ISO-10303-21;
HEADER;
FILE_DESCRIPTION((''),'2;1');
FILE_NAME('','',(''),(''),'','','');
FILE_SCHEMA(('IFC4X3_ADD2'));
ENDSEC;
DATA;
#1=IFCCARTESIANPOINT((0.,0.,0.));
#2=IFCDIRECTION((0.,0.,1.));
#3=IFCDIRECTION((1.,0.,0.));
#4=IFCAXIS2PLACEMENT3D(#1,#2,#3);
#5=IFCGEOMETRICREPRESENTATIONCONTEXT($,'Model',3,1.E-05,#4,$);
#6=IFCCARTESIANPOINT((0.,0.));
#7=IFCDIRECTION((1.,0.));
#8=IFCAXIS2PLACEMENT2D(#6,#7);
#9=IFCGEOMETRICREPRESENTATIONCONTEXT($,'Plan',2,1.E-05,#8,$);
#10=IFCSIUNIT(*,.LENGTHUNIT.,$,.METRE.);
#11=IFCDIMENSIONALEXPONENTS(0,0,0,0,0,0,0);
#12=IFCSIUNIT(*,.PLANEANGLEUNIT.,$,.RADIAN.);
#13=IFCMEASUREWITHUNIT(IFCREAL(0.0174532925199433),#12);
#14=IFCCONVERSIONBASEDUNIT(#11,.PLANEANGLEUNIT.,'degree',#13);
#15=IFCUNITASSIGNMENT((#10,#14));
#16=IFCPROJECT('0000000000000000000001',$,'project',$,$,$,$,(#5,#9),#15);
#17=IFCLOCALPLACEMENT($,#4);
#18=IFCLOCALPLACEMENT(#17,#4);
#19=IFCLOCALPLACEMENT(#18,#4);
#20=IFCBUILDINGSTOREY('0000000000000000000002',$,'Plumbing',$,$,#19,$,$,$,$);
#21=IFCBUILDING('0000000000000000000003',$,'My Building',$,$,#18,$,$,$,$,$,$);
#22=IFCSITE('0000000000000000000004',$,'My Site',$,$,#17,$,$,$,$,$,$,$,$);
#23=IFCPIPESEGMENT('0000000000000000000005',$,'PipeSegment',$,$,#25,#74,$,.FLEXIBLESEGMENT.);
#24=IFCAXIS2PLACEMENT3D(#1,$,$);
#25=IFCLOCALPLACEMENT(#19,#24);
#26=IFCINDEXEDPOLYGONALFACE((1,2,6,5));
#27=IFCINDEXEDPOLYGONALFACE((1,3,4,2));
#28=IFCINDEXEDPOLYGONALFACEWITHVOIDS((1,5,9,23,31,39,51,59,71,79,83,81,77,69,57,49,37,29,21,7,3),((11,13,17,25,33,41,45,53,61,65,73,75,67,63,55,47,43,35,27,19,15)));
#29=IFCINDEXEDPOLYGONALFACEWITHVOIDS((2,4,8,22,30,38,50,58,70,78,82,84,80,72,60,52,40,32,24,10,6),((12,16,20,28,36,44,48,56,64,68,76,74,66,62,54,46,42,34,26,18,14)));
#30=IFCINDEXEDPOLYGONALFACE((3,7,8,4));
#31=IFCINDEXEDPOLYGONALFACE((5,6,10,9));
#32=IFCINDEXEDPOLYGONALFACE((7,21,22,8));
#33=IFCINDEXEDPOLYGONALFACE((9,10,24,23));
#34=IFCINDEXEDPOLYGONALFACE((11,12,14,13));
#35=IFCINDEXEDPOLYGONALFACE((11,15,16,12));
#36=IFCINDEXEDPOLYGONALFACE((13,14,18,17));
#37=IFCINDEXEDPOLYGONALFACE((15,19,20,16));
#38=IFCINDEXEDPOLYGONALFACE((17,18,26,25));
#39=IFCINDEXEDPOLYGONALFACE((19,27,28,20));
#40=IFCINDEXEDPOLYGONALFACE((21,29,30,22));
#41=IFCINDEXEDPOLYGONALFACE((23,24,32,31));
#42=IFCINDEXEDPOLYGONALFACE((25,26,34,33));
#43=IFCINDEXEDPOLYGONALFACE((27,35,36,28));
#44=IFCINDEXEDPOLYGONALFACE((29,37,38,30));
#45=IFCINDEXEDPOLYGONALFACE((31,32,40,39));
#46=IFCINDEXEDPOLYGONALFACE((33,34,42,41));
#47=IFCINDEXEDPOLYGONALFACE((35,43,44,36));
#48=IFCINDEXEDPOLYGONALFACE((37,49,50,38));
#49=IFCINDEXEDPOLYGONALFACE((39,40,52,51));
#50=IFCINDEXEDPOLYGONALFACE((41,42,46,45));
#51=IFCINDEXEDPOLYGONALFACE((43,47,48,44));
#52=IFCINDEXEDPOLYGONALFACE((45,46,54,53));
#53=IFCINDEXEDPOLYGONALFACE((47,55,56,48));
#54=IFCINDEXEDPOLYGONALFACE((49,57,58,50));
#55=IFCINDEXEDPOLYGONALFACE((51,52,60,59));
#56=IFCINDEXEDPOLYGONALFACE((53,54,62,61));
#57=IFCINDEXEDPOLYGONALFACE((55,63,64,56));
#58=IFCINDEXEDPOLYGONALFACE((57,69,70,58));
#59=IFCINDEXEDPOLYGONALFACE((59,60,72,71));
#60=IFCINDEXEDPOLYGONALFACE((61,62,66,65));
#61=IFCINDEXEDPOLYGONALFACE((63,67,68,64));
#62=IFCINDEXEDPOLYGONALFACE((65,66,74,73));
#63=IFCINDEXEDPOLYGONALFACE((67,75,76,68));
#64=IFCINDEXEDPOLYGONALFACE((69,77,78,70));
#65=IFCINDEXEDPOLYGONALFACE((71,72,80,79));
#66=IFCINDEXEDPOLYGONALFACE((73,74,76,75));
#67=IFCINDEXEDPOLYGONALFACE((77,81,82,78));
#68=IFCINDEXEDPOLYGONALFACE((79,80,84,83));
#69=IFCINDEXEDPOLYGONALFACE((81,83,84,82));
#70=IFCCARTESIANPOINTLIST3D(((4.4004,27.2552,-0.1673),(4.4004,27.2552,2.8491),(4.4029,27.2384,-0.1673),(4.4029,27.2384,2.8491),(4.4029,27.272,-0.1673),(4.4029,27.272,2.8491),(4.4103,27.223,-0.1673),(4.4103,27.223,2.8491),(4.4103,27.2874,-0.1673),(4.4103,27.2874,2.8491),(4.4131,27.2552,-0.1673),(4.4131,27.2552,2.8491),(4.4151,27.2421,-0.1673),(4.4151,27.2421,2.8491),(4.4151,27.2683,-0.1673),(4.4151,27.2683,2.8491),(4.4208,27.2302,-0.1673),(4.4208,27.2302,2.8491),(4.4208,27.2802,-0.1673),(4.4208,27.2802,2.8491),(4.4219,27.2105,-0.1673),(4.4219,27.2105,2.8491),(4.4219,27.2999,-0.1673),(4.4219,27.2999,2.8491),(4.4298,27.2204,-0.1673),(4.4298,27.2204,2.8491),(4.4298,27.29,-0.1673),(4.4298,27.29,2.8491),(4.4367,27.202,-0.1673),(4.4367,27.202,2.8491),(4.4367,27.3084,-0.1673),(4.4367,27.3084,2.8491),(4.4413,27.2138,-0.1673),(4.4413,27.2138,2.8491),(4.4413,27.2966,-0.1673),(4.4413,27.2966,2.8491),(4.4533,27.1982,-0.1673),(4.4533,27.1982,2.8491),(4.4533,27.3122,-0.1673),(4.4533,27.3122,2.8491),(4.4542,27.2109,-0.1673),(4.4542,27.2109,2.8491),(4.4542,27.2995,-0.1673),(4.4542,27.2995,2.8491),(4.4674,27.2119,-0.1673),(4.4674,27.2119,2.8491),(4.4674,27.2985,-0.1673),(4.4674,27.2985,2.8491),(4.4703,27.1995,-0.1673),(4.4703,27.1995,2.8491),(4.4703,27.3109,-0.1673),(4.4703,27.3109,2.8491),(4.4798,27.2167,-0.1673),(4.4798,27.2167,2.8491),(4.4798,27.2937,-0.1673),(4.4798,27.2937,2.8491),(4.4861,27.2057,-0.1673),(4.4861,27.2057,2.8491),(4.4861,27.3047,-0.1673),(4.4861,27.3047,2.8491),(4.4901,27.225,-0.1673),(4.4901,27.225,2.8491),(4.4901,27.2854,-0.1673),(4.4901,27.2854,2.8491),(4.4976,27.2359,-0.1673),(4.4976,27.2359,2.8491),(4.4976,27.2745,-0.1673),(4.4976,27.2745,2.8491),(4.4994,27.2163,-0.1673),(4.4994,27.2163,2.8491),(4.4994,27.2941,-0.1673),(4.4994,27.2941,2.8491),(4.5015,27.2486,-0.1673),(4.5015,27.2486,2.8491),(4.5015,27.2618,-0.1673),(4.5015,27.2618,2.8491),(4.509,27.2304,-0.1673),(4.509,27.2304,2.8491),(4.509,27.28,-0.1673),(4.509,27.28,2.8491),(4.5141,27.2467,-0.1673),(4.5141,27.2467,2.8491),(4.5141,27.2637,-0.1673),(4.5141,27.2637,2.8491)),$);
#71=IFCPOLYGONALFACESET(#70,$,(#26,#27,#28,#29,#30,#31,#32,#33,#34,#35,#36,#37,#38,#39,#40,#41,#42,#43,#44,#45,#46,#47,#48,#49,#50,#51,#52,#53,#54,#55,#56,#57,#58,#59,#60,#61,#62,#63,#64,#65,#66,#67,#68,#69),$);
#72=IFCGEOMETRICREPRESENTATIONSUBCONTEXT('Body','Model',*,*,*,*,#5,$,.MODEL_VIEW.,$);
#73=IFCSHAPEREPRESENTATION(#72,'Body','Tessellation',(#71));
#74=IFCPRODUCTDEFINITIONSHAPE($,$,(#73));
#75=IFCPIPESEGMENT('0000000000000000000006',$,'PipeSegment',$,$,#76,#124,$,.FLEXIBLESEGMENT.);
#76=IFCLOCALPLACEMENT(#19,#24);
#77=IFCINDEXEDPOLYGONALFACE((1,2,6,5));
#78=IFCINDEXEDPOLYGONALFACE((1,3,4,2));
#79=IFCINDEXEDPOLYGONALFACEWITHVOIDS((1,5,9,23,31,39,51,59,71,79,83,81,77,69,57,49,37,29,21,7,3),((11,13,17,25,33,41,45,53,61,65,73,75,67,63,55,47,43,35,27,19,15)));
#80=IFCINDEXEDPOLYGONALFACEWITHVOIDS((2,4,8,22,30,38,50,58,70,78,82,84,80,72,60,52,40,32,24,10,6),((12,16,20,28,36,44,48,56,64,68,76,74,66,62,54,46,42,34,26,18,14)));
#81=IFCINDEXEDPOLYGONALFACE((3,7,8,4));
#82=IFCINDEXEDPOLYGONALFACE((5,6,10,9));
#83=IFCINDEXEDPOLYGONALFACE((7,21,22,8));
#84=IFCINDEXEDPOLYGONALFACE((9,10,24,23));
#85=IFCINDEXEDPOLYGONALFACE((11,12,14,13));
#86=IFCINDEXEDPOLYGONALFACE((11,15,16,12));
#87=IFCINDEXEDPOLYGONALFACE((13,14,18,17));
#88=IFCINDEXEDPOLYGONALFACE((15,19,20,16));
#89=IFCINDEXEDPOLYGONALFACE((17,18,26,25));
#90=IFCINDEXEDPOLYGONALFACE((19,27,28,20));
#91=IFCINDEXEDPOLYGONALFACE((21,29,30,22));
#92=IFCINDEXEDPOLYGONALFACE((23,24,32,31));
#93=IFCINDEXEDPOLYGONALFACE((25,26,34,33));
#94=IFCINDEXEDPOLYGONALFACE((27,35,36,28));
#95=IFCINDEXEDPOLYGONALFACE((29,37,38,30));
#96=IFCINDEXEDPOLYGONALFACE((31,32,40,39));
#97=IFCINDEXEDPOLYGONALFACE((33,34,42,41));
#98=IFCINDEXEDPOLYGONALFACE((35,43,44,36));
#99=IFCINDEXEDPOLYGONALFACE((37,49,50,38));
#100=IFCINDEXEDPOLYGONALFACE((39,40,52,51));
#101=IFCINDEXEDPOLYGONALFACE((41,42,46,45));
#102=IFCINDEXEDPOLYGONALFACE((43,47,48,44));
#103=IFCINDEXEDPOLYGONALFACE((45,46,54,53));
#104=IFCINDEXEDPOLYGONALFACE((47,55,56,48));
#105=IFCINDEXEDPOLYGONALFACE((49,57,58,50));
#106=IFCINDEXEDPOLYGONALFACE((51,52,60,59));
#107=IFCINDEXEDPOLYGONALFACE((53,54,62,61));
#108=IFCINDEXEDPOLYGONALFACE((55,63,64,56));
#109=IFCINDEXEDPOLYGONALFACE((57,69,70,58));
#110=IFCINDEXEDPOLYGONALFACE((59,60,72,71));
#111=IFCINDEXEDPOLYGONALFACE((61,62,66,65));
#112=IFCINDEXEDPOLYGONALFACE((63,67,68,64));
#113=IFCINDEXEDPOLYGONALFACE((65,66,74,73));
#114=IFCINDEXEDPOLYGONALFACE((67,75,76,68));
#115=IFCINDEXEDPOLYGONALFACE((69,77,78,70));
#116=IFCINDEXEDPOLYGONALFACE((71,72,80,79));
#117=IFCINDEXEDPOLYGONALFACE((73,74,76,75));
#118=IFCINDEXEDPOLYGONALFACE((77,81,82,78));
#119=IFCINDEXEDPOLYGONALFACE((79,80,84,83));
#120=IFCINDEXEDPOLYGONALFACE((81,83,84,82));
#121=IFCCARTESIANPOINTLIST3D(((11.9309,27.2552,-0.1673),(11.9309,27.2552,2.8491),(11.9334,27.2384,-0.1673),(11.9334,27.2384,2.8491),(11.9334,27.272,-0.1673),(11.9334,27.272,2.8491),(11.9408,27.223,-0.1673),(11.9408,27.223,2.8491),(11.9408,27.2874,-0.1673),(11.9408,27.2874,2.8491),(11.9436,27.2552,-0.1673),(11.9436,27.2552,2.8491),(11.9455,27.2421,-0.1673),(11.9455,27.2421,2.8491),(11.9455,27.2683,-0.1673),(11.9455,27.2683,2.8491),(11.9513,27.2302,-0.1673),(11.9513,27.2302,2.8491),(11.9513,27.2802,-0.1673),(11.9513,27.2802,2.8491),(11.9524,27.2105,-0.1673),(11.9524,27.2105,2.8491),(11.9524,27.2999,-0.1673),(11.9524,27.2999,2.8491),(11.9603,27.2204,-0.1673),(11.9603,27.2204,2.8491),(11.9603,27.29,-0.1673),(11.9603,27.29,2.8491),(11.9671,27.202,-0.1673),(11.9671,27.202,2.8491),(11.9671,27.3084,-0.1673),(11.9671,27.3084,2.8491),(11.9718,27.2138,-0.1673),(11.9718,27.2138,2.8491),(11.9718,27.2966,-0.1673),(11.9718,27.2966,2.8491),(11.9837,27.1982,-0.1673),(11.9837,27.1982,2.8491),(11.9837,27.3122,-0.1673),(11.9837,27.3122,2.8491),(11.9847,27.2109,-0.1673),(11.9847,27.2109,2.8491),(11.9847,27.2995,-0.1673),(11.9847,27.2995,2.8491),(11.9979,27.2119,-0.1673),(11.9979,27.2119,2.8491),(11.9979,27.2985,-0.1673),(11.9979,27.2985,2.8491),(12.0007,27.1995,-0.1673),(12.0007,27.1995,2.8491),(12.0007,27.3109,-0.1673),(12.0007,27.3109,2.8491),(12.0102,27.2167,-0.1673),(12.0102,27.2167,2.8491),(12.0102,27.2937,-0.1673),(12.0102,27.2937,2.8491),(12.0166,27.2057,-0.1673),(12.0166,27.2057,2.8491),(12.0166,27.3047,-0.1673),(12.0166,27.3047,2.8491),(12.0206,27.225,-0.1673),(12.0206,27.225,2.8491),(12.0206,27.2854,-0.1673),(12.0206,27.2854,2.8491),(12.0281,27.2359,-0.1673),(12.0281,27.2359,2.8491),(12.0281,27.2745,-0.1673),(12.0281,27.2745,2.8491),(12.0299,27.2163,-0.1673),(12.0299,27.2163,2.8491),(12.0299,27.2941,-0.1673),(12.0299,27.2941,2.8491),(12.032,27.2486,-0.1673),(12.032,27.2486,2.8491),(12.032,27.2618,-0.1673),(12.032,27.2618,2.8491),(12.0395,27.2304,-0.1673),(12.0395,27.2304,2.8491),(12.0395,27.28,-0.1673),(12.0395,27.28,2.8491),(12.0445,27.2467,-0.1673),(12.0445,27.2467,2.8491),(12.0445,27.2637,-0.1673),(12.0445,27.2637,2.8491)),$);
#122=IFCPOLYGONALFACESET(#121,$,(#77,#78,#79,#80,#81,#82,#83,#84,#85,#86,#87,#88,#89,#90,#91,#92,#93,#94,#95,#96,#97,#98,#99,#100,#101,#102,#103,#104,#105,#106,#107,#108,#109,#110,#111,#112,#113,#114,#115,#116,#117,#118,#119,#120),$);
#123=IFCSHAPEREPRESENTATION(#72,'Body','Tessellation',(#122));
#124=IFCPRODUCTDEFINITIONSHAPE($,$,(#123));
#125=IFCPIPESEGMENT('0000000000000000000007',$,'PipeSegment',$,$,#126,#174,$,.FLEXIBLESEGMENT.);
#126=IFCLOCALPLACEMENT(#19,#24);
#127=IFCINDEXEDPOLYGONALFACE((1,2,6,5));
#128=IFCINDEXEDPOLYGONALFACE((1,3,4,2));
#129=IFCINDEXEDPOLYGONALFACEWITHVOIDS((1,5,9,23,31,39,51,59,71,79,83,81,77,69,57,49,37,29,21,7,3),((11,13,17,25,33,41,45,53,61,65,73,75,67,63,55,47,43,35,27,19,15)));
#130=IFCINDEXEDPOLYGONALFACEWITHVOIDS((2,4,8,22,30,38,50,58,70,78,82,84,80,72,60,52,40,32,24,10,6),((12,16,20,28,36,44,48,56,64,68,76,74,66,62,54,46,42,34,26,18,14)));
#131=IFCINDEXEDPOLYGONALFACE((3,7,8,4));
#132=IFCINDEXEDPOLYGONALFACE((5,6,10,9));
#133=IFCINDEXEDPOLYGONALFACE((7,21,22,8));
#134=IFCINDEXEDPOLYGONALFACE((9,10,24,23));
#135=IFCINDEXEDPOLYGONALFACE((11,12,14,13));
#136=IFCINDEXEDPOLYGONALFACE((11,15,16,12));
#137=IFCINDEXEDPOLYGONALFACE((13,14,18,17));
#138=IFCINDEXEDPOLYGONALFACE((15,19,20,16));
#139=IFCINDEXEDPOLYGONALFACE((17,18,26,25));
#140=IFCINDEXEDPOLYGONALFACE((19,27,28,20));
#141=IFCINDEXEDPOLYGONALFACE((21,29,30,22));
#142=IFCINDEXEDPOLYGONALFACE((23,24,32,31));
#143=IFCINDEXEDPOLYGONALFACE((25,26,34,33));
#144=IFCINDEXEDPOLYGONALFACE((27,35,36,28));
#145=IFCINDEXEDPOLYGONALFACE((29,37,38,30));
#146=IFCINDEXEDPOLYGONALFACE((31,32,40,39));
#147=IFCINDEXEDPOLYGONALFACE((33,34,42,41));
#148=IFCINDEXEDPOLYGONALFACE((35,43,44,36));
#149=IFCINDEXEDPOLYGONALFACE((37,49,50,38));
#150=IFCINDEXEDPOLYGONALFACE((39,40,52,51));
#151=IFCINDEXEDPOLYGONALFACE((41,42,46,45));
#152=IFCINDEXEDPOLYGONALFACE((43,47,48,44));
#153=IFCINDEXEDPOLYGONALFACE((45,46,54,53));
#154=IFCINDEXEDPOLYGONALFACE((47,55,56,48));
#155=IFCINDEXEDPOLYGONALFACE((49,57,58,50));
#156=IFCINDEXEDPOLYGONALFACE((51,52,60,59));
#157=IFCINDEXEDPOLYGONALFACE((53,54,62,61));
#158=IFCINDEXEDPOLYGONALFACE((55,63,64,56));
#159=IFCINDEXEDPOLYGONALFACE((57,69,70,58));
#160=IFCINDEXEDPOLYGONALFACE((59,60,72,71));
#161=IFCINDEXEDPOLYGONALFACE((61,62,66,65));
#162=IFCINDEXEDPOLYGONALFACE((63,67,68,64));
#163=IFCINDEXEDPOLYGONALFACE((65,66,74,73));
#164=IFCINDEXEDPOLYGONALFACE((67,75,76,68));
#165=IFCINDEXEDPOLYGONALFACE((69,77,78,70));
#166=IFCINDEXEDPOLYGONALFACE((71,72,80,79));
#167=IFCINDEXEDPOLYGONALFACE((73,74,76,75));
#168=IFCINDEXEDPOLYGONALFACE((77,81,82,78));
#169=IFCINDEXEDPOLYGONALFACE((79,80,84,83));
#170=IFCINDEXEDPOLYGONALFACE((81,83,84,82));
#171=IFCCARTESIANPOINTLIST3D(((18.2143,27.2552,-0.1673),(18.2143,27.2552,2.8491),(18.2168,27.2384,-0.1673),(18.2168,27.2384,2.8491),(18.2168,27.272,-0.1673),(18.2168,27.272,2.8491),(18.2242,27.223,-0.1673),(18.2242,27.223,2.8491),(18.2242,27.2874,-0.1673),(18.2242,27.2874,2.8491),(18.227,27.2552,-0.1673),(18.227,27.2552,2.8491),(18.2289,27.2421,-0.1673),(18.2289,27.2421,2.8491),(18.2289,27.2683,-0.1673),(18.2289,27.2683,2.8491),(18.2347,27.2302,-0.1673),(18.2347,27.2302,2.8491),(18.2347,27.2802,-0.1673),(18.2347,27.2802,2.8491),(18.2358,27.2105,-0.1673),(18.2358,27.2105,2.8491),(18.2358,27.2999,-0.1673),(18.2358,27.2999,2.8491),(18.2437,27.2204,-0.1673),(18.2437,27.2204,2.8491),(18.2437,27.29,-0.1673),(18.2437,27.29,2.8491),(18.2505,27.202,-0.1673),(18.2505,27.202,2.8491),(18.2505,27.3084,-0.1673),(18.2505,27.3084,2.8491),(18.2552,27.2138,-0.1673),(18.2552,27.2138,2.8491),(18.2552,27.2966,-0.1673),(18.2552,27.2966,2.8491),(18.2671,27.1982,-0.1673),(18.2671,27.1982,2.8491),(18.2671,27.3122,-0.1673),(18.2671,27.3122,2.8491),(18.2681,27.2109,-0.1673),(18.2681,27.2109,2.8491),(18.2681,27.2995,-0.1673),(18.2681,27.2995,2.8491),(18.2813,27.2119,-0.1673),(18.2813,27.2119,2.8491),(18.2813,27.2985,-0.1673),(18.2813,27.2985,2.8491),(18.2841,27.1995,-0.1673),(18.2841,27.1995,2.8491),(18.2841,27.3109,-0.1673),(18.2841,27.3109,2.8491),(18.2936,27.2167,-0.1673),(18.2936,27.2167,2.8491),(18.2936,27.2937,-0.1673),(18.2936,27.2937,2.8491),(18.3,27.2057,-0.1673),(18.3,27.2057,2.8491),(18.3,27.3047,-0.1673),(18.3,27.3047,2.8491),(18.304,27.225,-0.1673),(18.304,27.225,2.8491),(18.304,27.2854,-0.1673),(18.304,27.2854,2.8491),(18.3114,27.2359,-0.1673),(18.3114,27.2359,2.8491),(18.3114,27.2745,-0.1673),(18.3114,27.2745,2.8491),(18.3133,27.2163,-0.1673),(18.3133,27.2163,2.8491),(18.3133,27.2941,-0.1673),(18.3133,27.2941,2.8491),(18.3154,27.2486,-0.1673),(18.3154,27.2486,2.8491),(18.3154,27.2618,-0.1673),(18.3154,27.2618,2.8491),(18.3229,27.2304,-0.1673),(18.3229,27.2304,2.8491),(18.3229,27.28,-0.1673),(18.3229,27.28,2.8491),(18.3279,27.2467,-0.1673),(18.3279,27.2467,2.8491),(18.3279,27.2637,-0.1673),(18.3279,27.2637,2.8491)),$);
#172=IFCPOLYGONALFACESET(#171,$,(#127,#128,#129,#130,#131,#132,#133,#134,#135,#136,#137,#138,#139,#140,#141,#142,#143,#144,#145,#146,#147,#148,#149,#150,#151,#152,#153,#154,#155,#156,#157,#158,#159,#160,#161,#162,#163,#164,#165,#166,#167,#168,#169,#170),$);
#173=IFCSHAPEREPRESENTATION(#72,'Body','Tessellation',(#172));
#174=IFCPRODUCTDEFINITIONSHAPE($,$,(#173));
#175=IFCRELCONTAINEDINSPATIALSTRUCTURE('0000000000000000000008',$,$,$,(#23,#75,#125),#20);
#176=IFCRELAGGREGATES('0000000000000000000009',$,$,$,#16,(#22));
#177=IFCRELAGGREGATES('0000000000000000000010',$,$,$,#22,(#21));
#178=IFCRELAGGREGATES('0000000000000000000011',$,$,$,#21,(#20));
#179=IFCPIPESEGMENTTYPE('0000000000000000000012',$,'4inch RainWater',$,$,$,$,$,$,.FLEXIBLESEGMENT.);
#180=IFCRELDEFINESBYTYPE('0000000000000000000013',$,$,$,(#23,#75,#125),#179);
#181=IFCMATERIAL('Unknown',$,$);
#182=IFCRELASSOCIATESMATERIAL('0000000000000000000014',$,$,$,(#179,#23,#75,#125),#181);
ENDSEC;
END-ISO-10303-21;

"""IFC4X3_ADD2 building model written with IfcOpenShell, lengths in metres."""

from ifc_helpers import new_model, entity, si_unit, converted_unit, frame, origin_with_axes, origin_2d_with_axis, place, context, subcontext, project, spatial, hollow_circle, extrude, material, material_profile, profile_set, profile_usage, type_object, element, save


model = new_model("IFC4X3_ADD2")

# Units and contexts
model_context = context("Model", 3, precision=1e-05, world=origin_with_axes())
plan_context = context("Plan", 2, precision=1e-05, world=origin_2d_with_axis())
body_context = subcontext(model_context, "Body", "Model", "MODEL_VIEW")
ifc_project = project(units=[si_unit("LENGTHUNIT", "METRE"), converted_unit("PLANEANGLEUNIT", "degree", entity("IfcReal", 0.0174532925199433), si_unit("PLANEANGLEUNIT", "RADIAN"), dimensions=[0, 0, 0, 0, 0, 0, 0])], contexts=[model_context, plan_context])

# Site, building, storey
site_placement = place(None, origin_with_axes())
site = spatial("IfcSite", under=ifc_project, at=site_placement, Name="My Site")
building_placement = place(site_placement, origin_with_axes())
building = spatial("IfcBuilding", under=site, at=building_placement, Name="My Building")
storey_placement = place(building_placement, origin_with_axes())
storey = spatial("IfcBuildingStorey", under=building, at=storey_placement, Name="Plumbing")

# Pipe segments
ifc_material_1 = material(Name="Unknown")
ifc_material_profile_1 = material_profile(ifc_material_1, hollow_circle(Radius=0.0571, WallThickness=0.0127))
ifc_profile_set_1 = profile_set([ifc_material_profile_1], Name="rainwater")
ifc_profile_usage_1 = profile_usage(ifc_profile_set_1)
ifc_material_profile_2 = material_profile(ifc_material_1, hollow_circle(Radius=0.0571, WallThickness=0.0127))
ifc_profile_set_2 = profile_set([ifc_material_profile_2], Name="rainwater")
pipe_segment_type_1 = type_object("IfcPipeSegmentType", Name="4inch RainWater", PredefinedType="FLEXIBLESEGMENT", material=ifc_profile_set_2)
pipe_segment_1_placement = place(storey_placement, frame((4.4576, 27.2552, -0.1673), z_axis=(0.0, 0.0, 1.0), x_axis=(-1.0, 0.0, 0.0)))
element("IfcPipeSegment", 1, at=pipe_segment_1_placement, inside=storey, type_object=pipe_segment_type_1, material=ifc_profile_usage_1, Name="PipeSegment", PredefinedType="FLEXIBLESEGMENT", context=body_context, shape_type="SweptSolid", body=[
    extrude(hollow_circle(Radius=0.0571, WallThickness=0.0127), origin_with_axes(), (0.0, 0.0, 1.0), 3.0165),
])
ifc_profile_usage_2 = profile_usage(ifc_profile_set_1)
pipe_segment_2_placement = place(storey_placement, frame((11.988, 27.2552, -0.1673), z_axis=(0.0, 0.0, 1.0), x_axis=(-1.0, 0.0, 0.0)))
element("IfcPipeSegment", 2, at=pipe_segment_2_placement, inside=storey, type_object=pipe_segment_type_1, material=ifc_profile_usage_2, Name="PipeSegment", PredefinedType="FLEXIBLESEGMENT", context=body_context, shape_type="SweptSolid", body=[
    extrude(hollow_circle(Radius=0.0571, WallThickness=0.0127), origin_with_axes(), (0.0, 0.0, 1.0), 3.0165),
])
ifc_profile_usage_3 = profile_usage(ifc_profile_set_1)
pipe_segment_3_placement = place(storey_placement, frame((18.2714, 27.2552, -0.1673), z_axis=(0.0, 0.0, 1.0), x_axis=(-1.0, 0.0, 0.0)))
element("IfcPipeSegment", 3, at=pipe_segment_3_placement, inside=storey, type_object=pipe_segment_type_1, material=ifc_profile_usage_3, Name="PipeSegment", PredefinedType="FLEXIBLESEGMENT", context=body_context, shape_type="SweptSolid", body=[
    extrude(hollow_circle(Radius=0.0571, WallThickness=0.0127), origin_with_axes(), (0.0, 0.0, 1.0), 3.0165),
])

save(model, "model.ifc")
